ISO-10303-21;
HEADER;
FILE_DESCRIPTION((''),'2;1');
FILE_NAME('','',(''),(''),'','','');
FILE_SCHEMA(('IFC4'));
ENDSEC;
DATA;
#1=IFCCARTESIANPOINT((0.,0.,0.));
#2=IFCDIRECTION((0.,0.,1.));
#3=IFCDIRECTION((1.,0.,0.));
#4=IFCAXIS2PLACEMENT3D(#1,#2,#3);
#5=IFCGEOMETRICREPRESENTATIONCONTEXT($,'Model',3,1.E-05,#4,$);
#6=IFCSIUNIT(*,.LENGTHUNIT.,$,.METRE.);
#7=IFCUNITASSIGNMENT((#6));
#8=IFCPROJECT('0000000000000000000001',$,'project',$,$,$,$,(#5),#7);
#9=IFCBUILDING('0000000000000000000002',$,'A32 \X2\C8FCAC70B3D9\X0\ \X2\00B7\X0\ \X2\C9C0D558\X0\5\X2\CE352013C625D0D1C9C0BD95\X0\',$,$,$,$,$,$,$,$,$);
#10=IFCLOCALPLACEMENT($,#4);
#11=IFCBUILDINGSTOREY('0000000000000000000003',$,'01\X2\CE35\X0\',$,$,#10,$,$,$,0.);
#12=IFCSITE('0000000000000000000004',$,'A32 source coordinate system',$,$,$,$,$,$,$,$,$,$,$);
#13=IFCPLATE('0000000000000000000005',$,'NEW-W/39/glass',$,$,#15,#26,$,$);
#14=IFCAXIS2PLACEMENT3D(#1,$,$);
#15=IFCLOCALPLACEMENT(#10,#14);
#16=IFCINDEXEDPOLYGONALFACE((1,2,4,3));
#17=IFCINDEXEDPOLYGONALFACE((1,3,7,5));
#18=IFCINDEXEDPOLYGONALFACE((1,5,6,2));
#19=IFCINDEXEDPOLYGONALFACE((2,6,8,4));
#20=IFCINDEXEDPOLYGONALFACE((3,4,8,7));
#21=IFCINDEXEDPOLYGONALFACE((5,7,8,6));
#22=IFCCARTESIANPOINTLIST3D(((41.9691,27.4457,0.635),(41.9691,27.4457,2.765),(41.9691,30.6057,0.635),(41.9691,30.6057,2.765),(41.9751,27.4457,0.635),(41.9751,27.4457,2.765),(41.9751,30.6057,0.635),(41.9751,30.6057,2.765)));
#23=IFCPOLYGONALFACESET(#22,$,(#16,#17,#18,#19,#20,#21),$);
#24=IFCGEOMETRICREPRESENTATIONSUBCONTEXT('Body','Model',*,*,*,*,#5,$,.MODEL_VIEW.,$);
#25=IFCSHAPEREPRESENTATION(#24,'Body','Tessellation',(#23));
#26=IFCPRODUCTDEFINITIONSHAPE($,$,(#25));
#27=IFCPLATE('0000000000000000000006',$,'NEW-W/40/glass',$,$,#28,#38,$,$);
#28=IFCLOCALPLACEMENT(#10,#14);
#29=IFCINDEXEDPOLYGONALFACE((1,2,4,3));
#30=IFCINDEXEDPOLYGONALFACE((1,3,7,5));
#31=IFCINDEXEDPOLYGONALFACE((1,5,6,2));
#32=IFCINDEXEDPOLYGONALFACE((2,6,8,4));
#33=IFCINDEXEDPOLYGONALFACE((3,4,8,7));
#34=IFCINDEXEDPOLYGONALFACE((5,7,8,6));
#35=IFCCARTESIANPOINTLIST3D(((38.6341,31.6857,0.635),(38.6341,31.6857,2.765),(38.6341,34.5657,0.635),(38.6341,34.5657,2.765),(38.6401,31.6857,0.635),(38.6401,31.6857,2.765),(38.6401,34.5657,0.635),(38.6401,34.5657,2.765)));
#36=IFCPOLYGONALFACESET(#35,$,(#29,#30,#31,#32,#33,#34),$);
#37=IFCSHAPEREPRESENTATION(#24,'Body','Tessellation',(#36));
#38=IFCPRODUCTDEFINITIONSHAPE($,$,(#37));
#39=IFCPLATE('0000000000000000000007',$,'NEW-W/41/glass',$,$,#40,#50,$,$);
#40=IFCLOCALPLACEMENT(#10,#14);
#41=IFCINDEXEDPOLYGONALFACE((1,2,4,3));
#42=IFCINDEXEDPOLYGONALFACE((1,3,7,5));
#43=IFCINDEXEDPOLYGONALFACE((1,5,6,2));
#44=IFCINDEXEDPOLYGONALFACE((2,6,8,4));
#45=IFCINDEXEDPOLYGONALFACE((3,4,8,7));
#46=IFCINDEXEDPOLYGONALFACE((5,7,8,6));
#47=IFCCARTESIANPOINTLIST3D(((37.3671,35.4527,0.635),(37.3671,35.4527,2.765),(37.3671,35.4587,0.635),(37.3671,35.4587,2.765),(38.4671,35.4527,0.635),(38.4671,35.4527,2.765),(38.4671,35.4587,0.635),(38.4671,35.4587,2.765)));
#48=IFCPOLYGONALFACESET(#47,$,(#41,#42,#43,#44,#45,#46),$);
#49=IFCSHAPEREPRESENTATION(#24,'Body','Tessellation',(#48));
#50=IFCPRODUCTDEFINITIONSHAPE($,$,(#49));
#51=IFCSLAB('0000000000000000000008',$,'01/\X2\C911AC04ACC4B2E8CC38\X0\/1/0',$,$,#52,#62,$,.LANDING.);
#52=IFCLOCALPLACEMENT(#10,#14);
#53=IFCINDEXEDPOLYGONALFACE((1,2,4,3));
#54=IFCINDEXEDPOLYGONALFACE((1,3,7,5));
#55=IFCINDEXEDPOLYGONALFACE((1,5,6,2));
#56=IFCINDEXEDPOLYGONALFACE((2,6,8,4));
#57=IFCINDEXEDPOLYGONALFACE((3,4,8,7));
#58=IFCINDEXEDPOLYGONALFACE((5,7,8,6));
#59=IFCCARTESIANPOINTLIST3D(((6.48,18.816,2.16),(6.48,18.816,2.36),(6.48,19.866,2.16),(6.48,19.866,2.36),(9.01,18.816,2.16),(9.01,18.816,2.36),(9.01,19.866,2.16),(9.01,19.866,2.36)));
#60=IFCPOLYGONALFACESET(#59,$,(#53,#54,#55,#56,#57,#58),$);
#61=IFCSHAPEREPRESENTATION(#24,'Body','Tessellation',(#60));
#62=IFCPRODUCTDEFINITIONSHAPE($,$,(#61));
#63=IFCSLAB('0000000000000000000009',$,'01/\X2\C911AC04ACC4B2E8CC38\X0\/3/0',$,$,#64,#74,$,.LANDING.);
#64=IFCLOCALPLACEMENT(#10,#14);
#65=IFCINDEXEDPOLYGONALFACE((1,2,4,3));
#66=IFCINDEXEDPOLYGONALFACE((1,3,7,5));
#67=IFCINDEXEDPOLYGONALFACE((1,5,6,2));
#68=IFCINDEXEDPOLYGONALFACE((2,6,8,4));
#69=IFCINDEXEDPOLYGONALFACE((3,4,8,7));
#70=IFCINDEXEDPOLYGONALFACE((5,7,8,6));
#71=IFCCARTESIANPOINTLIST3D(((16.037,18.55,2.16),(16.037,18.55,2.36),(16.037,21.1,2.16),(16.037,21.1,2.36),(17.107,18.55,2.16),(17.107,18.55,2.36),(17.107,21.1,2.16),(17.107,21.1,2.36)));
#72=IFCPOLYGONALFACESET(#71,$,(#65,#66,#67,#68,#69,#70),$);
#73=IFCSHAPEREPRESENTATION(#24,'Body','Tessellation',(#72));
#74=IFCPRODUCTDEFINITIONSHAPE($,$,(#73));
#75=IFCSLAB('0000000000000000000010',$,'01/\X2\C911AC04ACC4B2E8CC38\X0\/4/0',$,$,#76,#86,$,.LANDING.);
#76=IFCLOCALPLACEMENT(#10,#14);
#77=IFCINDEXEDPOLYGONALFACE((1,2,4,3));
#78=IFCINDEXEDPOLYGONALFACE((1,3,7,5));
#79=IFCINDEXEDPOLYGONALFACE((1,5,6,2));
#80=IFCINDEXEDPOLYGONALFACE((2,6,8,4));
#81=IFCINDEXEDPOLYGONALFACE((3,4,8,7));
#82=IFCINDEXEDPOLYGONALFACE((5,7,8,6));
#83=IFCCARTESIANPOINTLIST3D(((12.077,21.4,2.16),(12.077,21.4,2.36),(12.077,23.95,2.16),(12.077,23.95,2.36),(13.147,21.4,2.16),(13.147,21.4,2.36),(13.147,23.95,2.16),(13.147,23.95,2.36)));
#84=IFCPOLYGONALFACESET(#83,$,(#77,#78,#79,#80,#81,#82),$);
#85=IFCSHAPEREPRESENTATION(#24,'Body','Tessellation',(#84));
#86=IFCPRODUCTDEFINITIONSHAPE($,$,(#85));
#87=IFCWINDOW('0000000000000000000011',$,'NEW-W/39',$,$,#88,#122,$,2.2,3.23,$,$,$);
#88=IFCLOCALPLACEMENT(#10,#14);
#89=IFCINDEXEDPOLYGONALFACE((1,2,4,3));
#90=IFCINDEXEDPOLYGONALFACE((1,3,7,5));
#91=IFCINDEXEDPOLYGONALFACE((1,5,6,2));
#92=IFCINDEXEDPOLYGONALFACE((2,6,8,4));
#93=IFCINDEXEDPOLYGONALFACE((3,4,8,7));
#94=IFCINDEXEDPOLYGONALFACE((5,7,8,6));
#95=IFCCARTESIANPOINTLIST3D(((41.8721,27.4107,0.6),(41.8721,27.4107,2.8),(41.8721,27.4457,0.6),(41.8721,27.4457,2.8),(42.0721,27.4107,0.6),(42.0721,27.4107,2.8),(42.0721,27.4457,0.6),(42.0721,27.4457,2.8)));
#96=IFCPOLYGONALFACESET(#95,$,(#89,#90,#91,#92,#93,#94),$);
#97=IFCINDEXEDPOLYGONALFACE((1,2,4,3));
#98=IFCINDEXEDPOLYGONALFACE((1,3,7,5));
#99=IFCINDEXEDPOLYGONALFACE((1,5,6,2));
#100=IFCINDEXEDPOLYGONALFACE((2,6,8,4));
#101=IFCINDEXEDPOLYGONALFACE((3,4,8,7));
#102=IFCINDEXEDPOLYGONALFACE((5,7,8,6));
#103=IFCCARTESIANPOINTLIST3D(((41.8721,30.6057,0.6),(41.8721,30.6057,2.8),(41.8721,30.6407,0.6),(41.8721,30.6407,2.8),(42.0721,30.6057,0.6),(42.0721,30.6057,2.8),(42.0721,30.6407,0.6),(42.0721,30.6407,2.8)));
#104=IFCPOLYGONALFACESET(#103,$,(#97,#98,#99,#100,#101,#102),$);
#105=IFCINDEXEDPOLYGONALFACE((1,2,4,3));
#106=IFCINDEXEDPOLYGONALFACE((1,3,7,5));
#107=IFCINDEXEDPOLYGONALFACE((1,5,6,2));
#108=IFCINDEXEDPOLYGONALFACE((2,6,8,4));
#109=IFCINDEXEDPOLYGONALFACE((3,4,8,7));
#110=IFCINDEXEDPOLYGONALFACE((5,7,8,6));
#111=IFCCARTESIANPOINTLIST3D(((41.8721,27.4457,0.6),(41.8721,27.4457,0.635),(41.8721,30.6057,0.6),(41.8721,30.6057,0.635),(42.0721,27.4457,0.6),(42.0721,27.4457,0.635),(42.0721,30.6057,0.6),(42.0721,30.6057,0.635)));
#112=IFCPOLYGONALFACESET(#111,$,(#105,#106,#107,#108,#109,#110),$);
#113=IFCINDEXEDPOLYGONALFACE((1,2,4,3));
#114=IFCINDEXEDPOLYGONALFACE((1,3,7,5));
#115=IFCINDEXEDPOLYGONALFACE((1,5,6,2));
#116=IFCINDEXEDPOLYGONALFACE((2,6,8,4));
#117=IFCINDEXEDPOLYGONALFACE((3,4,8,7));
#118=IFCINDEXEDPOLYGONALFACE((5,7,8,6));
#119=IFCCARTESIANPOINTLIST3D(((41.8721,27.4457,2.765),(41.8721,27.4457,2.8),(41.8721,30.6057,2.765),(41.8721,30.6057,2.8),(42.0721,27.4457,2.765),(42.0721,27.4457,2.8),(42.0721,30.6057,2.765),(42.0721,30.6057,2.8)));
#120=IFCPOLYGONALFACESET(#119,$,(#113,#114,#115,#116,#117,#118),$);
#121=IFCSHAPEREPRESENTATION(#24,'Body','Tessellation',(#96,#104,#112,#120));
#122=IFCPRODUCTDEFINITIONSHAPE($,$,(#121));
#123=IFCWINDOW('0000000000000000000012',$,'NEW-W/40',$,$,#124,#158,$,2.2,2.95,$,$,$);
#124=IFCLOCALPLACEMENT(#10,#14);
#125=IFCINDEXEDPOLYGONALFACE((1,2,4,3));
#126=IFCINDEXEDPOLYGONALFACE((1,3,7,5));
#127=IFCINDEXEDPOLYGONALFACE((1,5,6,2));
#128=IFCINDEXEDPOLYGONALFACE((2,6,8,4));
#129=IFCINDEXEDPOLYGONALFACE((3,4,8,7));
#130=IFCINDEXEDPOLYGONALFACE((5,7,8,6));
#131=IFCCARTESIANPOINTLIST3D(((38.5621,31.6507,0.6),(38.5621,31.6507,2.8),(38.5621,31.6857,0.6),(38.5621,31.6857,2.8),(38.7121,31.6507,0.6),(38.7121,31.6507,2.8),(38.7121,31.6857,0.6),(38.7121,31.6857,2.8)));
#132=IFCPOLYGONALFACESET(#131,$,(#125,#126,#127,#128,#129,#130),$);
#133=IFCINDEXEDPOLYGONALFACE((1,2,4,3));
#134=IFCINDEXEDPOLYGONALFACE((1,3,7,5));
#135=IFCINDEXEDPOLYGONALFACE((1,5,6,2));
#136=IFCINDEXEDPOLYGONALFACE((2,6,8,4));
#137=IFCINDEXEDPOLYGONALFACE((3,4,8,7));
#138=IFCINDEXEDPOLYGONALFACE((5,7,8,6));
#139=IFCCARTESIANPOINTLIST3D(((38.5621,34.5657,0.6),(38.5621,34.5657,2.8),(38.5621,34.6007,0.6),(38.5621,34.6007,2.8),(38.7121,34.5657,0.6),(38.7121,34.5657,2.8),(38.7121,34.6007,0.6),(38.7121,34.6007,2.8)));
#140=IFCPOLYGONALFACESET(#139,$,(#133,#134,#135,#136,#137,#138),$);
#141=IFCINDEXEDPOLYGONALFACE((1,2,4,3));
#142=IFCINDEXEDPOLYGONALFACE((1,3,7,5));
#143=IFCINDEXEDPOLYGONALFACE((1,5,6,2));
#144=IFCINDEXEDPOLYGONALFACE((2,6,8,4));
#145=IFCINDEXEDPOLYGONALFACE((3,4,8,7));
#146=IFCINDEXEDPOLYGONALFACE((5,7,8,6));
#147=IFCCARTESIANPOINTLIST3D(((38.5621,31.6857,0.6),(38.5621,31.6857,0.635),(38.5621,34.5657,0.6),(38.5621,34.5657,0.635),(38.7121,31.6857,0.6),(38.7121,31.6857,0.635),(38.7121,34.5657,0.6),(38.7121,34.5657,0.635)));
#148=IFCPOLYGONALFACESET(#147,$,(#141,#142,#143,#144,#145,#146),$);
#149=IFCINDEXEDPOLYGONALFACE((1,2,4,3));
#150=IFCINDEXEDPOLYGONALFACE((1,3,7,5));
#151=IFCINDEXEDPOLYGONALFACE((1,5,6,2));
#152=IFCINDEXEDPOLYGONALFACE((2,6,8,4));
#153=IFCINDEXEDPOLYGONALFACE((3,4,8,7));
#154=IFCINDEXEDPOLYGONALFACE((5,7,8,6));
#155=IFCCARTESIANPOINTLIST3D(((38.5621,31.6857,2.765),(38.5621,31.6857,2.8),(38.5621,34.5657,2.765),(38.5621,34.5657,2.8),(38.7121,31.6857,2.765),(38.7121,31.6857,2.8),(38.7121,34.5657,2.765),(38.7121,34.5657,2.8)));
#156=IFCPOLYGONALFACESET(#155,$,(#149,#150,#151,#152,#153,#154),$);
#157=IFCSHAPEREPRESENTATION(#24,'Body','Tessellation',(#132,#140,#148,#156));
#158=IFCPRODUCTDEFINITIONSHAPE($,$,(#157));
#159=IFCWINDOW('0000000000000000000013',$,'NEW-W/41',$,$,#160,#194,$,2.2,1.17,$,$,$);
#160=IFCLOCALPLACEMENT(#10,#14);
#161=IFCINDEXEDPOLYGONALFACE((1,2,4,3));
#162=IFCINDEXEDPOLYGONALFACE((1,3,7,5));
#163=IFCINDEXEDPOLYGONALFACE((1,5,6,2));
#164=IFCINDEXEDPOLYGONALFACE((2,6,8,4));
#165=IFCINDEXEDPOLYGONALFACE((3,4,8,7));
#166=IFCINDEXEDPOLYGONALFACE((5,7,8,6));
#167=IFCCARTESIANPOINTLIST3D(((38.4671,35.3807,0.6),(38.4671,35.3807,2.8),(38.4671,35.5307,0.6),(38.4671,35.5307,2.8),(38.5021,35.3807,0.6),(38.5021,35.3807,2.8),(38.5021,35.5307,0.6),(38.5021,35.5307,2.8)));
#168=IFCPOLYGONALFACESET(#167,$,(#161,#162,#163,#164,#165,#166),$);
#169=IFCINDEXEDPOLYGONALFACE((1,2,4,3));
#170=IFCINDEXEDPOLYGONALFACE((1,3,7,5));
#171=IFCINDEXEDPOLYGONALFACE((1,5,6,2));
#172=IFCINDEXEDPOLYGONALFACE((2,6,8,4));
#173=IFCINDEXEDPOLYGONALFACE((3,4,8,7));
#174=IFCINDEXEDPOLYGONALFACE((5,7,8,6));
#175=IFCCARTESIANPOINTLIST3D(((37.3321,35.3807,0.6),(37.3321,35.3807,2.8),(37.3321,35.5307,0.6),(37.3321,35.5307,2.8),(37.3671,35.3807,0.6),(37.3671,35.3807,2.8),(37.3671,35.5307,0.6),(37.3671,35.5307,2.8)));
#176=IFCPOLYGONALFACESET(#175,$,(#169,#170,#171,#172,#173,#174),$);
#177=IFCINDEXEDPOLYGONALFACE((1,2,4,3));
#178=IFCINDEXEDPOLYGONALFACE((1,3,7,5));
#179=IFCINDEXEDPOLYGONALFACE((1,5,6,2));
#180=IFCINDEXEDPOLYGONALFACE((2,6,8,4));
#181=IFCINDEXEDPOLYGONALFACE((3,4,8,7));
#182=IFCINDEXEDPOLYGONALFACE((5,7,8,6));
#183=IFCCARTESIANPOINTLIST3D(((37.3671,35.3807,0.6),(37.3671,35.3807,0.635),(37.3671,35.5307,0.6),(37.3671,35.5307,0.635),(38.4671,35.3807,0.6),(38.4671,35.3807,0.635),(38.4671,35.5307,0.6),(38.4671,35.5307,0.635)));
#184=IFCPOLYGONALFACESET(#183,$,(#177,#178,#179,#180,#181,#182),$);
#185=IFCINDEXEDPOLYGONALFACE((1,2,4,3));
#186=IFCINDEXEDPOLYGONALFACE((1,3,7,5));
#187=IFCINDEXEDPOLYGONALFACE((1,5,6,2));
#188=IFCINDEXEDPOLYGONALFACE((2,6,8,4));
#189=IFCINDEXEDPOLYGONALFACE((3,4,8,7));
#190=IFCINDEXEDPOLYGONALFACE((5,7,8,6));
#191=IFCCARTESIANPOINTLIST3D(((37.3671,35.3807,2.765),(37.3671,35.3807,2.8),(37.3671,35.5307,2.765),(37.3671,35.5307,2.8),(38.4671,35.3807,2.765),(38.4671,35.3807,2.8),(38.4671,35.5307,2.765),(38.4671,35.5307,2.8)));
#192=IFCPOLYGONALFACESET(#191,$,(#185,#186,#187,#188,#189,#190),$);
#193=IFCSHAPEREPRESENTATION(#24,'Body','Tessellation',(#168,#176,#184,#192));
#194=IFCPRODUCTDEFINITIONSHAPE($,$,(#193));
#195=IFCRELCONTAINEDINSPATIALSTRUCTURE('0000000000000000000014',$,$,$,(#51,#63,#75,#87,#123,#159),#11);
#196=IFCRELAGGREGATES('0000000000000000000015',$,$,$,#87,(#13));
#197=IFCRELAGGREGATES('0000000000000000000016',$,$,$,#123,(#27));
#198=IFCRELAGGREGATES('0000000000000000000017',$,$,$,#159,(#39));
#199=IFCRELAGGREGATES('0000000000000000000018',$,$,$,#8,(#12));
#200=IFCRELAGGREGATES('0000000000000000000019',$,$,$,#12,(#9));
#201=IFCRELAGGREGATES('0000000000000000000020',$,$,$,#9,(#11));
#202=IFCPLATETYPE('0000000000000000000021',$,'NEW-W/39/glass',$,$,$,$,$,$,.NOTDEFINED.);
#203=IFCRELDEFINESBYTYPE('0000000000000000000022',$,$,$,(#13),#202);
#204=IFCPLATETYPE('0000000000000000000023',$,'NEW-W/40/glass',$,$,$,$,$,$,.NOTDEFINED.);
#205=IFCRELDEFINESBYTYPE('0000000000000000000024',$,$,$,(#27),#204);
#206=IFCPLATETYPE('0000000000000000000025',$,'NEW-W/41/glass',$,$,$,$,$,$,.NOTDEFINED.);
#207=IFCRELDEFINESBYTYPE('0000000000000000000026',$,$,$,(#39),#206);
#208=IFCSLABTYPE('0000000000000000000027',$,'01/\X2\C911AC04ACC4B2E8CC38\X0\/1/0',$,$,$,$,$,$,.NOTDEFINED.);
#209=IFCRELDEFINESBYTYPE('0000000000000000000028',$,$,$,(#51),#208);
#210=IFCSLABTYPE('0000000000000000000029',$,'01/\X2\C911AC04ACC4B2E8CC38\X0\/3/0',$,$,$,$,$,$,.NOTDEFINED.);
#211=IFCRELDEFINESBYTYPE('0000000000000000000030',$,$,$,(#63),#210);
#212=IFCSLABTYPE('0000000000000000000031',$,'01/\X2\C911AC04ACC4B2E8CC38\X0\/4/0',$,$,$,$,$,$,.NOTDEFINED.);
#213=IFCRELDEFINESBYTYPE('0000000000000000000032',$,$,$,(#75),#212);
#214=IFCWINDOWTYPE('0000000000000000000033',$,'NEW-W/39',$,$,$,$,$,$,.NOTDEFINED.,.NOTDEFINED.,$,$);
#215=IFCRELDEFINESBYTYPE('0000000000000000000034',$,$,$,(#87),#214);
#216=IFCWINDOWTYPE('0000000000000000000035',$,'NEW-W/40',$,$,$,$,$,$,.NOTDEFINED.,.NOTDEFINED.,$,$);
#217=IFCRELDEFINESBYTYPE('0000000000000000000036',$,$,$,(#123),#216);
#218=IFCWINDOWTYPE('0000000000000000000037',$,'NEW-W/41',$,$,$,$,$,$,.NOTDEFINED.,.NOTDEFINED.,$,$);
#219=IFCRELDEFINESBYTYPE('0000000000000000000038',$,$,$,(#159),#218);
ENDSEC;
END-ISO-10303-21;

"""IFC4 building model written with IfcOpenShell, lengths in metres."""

from ifc_helpers import new_model, si_unit, frame, origin, origin_with_axes, place, context, subcontext, project, spatial, polyline, outline, extrude, source, transform, mapped, type_object, type_shapes, element, aggregate, save


model = new_model("IFC4")

# Units and contexts
model_context = context("Model", 3, precision=1e-05, world=origin_with_axes())
body_context = subcontext(model_context, "Body", "Model", "MODEL_VIEW")
ifc_project = project(units=[si_unit("LENGTHUNIT", "METRE")], contexts=[model_context])

# Plates
storey_placement = place(None, origin_with_axes())
plate_type_1 = type_object("IfcPlateType", Name="NEW-W/39/glass", PredefinedType="NOTDEFINED")
shared_shape_1 = source(origin(), body_context, "Body", "SweptSolid", [
    extrude(outline(polyline([(41.9751, 27.4457), (41.9691, 27.4457), (41.9691, 30.6057), (41.9751, 30.6057), (41.9751, 27.4457)])), frame((0.0, 0.0, 0.635)), (0.0, 0.0, 1.0), 2.13),
])
type_shapes(plate_type_1, [shared_shape_1])
window_1_placement = place(storey_placement, origin_with_axes())
plate_1_placement = place(window_1_placement, origin_with_axes())
plate_1 = element("IfcPlate", 1, at=plate_1_placement, type_object=plate_type_1, Name="NEW-W/39/glass", context=body_context, shape_type="MappedRepresentation", body=[
    mapped(shared_shape_1, transform((0.0, 0.0, 0.0), scale=1.0)),
])
plate_type_2 = type_object("IfcPlateType", Name="NEW-W/40/glass", PredefinedType="NOTDEFINED")
shared_shape_2 = source(origin(), body_context, "Body", "SweptSolid", [
    extrude(outline(polyline([(38.6401, 31.6857), (38.6341, 31.6857), (38.6341, 34.5657), (38.6401, 34.5657), (38.6401, 31.6857)])), frame((0.0, 0.0, 0.635)), (0.0, 0.0, 1.0), 2.13),
])
type_shapes(plate_type_2, [shared_shape_2])
window_2_placement = place(storey_placement, origin_with_axes())
plate_2_placement = place(window_2_placement, origin_with_axes())
plate_2 = element("IfcPlate", 2, at=plate_2_placement, type_object=plate_type_2, Name="NEW-W/40/glass", context=body_context, shape_type="MappedRepresentation", body=[
    mapped(shared_shape_2, transform((0.0, 0.0, 0.0), scale=1.0)),
])
plate_type_3 = type_object("IfcPlateType", Name="NEW-W/41/glass", PredefinedType="NOTDEFINED")
shared_shape_3 = source(origin(), body_context, "Body", "SweptSolid", [
    extrude(outline(polyline([(38.4671, 35.4527), (37.3671, 35.4527), (37.3671, 35.4587), (38.4671, 35.4587), (38.4671, 35.4527)])), frame((0.0, 0.0, 0.635)), (0.0, 0.0, 1.0), 2.13),
])
type_shapes(plate_type_3, [shared_shape_3])
window_3_placement = place(storey_placement, origin_with_axes())
plate_3_placement = place(window_3_placement, origin_with_axes())
plate_3 = element("IfcPlate", 3, at=plate_3_placement, type_object=plate_type_3, Name="NEW-W/41/glass", context=body_context, shape_type="MappedRepresentation", body=[
    mapped(shared_shape_3, transform((0.0, 0.0, 0.0), scale=1.0)),
])

# Site, building, storey
site = spatial("IfcSite", under=ifc_project, Name="A32 source coordinate system")
building = spatial("IfcBuilding", under=site, Name="A32 주거동 · 지하5층–옥탑지붕")
storey = spatial("IfcBuildingStorey", under=building, at=storey_placement, Name="01층", Elevation=0.0)

# Slabs
slab_type_1 = type_object("IfcSlabType", Name="01/중간계단참/1/0", PredefinedType="NOTDEFINED")
shared_shape_4 = source(origin(), body_context, "Body", "SweptSolid", [
    extrude(outline(polyline([(9.01, 18.816), (6.48, 18.816), (6.48, 19.866), (9.01, 19.866), (9.01, 18.816)])), frame((0.0, 0.0, 2.16)), (0.0, 0.0, 1.0), 0.2),
])
type_shapes(slab_type_1, [shared_shape_4])
slab_1_placement = place(storey_placement, origin_with_axes())
element("IfcSlab", 4, at=slab_1_placement, inside=storey, type_object=slab_type_1, Name="01/중간계단참/1/0", PredefinedType="LANDING", context=body_context, shape_type="MappedRepresentation", body=[
    mapped(shared_shape_4, transform((0.0, 0.0, 0.0), scale=1.0)),
])
slab_type_2 = type_object("IfcSlabType", Name="01/중간계단참/3/0", PredefinedType="NOTDEFINED")
shared_shape_5 = source(origin(), body_context, "Body", "SweptSolid", [
    extrude(outline(polyline([(17.107, 18.55), (16.037, 18.55), (16.037, 21.1), (17.107, 21.1), (17.107, 18.55)])), frame((0.0, 0.0, 2.16)), (0.0, 0.0, 1.0), 0.2),
])
type_shapes(slab_type_2, [shared_shape_5])
slab_2_placement = place(storey_placement, origin_with_axes())
element("IfcSlab", 5, at=slab_2_placement, inside=storey, type_object=slab_type_2, Name="01/중간계단참/3/0", PredefinedType="LANDING", context=body_context, shape_type="MappedRepresentation", body=[
    mapped(shared_shape_5, transform((0.0, 0.0, 0.0), scale=1.0)),
])
slab_type_3 = type_object("IfcSlabType", Name="01/중간계단참/4/0", PredefinedType="NOTDEFINED")
shared_shape_6 = source(origin(), body_context, "Body", "SweptSolid", [
    extrude(outline(polyline([(13.147, 21.4), (12.077, 21.4), (12.077, 23.95), (13.147, 23.95), (13.147, 21.4)])), frame((0.0, 0.0, 2.16)), (0.0, 0.0, 1.0), 0.2),
])
type_shapes(slab_type_3, [shared_shape_6])
slab_3_placement = place(storey_placement, origin_with_axes())
element("IfcSlab", 6, at=slab_3_placement, inside=storey, type_object=slab_type_3, Name="01/중간계단참/4/0", PredefinedType="LANDING", context=body_context, shape_type="MappedRepresentation", body=[
    mapped(shared_shape_6, transform((0.0, 0.0, 0.0), scale=1.0)),
])

# Windows
window_type_1 = type_object("IfcWindowType", Name="NEW-W/39", PartitioningType="NOTDEFINED", PredefinedType="NOTDEFINED")
shared_shape_7 = source(origin(), body_context, "Body", "SweptSolid", [
    extrude(outline(polyline([(41.8721, 27.4107), (41.8721, 27.4457), (42.0721, 27.4457), (42.0721, 27.4107), (41.8721, 27.4107)])), frame((0.0, 0.0, 0.6)), (0.0, 0.0, 1.0), 2.2),
    extrude(outline(polyline([(41.8721, 30.6057), (41.8721, 30.6407), (42.0721, 30.6407), (42.0721, 30.6057), (41.8721, 30.6057)])), frame((0.0, 0.0, 0.6)), (0.0, 0.0, 1.0), 2.2),
    extrude(outline(polyline([(42.0721, 27.4457), (42.0721, 30.6057), (41.8721, 30.6057), (41.8721, 27.4457), (42.0721, 27.4457)])), frame((0.0, 0.0, 0.6)), (0.0, 0.0, 1.0), 0.035),
    extrude(outline(polyline([(42.0721, 27.4457), (42.0721, 30.6057), (41.8721, 30.6057), (41.8721, 27.4457), (42.0721, 27.4457)])), frame((0.0, 0.0, 2.765)), (0.0, 0.0, 1.0), 0.035),
])
type_shapes(window_type_1, [shared_shape_7])
window_1 = element("IfcWindow", 7, at=window_1_placement, inside=storey, type_object=window_type_1, Name="NEW-W/39", OverallHeight=2.2, OverallWidth=3.23, context=body_context, shape_type="MappedRepresentation", body=[
    mapped(shared_shape_7, transform((0.0, 0.0, 0.0), scale=1.0)),
])
aggregate(window_1, [plate_1])
window_type_2 = type_object("IfcWindowType", Name="NEW-W/40", PartitioningType="NOTDEFINED", PredefinedType="NOTDEFINED")
shared_shape_8 = source(origin(), body_context, "Body", "SweptSolid", [
    extrude(outline(polyline([(38.5621, 31.6507), (38.5621, 31.6857), (38.7121, 31.6857), (38.7121, 31.6507), (38.5621, 31.6507)])), frame((0.0, 0.0, 0.6)), (0.0, 0.0, 1.0), 2.2),
    extrude(outline(polyline([(38.5621, 34.5657), (38.5621, 34.6007), (38.7121, 34.6007), (38.7121, 34.5657), (38.5621, 34.5657)])), frame((0.0, 0.0, 0.6)), (0.0, 0.0, 1.0), 2.2),
    extrude(outline(polyline([(38.7121, 31.6857), (38.7121, 34.5657), (38.5621, 34.5657), (38.5621, 31.6857), (38.7121, 31.6857)])), frame((0.0, 0.0, 0.6)), (0.0, 0.0, 1.0), 0.035),
    extrude(outline(polyline([(38.7121, 31.6857), (38.7121, 34.5657), (38.5621, 34.5657), (38.5621, 31.6857), (38.7121, 31.6857)])), frame((0.0, 0.0, 2.765)), (0.0, 0.0, 1.0), 0.035),
])
type_shapes(window_type_2, [shared_shape_8])
window_2 = element("IfcWindow", 8, at=window_2_placement, inside=storey, type_object=window_type_2, Name="NEW-W/40", OverallHeight=2.2, OverallWidth=2.95, context=body_context, shape_type="MappedRepresentation", body=[
    mapped(shared_shape_8, transform((0.0, 0.0, 0.0), scale=1.0)),
])
aggregate(window_2, [plate_2])
window_type_3 = type_object("IfcWindowType", Name="NEW-W/41", PartitioningType="NOTDEFINED", PredefinedType="NOTDEFINED")
shared_shape_9 = source(origin(), body_context, "Body", "SweptSolid", [
    extrude(outline(polyline([(38.4671, 35.3807), (38.4671, 35.5307), (38.5021, 35.5307), (38.5021, 35.3807), (38.4671, 35.3807)])), frame((0.0, 0.0, 0.6)), (0.0, 0.0, 1.0), 2.2),
    extrude(outline(polyline([(37.3321, 35.3807), (37.3321, 35.5307), (37.3671, 35.5307), (37.3671, 35.3807), (37.3321, 35.3807)])), frame((0.0, 0.0, 0.6)), (0.0, 0.0, 1.0), 2.2),
    extrude(outline(polyline([(38.4671, 35.3807), (38.4671, 35.5307), (37.3671, 35.5307), (37.3671, 35.3807), (38.4671, 35.3807)])), frame((0.0, 0.0, 0.6)), (0.0, 0.0, 1.0), 0.035),
    extrude(outline(polyline([(38.4671, 35.3807), (38.4671, 35.5307), (37.3671, 35.5307), (37.3671, 35.3807), (38.4671, 35.3807)])), frame((0.0, 0.0, 2.765)), (0.0, 0.0, 1.0), 0.035),
])
type_shapes(window_type_3, [shared_shape_9])
window_3 = element("IfcWindow", 9, at=window_3_placement, inside=storey, type_object=window_type_3, Name="NEW-W/41", OverallHeight=2.2, OverallWidth=1.17, context=body_context, shape_type="MappedRepresentation", body=[
    mapped(shared_shape_9, transform((0.0, 0.0, 0.0), scale=1.0)),
])
aggregate(window_3, [plate_3])

save(model, "model.ifc")
